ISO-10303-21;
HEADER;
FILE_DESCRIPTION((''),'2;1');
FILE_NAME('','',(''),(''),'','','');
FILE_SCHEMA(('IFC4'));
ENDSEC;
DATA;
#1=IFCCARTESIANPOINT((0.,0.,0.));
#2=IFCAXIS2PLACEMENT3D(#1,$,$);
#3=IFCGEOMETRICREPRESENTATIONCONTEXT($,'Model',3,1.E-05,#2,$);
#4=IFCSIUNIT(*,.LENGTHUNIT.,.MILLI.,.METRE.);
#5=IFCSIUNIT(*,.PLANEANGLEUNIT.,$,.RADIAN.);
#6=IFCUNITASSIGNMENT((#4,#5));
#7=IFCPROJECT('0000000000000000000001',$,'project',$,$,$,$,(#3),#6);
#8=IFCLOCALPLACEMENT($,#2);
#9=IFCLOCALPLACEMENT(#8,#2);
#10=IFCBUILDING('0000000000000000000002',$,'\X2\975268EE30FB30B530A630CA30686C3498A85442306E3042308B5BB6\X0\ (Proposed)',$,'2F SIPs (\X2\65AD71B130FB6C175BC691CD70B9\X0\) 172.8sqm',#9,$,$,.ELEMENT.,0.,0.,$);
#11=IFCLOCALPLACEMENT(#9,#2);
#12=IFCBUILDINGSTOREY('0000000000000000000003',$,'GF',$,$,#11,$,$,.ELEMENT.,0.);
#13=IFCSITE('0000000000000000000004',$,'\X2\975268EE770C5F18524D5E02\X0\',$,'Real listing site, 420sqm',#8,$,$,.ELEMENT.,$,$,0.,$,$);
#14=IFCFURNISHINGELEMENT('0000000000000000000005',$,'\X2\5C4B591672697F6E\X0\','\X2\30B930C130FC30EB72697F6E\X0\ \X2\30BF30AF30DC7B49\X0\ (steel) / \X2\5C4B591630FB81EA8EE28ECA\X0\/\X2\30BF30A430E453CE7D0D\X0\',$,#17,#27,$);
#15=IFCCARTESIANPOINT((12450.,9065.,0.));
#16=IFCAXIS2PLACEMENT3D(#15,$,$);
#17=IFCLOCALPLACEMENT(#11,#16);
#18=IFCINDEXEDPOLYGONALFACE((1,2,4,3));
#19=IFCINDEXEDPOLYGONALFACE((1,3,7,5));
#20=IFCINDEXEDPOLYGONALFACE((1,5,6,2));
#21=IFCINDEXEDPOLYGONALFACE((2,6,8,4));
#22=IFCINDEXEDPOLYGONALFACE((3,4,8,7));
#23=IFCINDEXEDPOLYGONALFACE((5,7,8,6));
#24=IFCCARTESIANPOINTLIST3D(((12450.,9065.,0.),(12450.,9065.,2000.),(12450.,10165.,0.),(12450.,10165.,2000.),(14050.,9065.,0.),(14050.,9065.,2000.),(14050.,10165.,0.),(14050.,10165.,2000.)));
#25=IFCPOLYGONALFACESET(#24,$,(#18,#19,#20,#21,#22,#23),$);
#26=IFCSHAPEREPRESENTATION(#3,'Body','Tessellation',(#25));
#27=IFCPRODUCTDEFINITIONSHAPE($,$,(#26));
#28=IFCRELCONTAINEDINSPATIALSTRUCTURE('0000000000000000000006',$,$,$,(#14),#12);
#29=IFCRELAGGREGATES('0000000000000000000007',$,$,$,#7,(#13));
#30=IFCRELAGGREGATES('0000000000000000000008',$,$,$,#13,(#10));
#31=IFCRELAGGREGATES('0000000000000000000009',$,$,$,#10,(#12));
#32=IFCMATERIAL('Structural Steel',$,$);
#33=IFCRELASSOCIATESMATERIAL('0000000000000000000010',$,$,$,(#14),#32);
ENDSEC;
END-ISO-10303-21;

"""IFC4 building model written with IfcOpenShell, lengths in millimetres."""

from ifc_helpers import new_model, si_unit, frame, frame_2d, origin, place, context, project, spatial, rectangle, extrude, material, element, save


model = new_model("IFC4")

# Units and contexts
model_context = context("Model", 3, precision=1e-05, world=origin())
ifc_project = project(units=[si_unit("LENGTHUNIT", "METRE", prefix="MILLI"), si_unit("PLANEANGLEUNIT", "RADIAN")], contexts=[model_context])

# Site, building, storey
site_placement = place(None, origin())
site = spatial("IfcSite", under=ifc_project, at=site_placement, Name="青森県弘前市", ObjectType="Real listing site, 420sqm", CompositionType="ELEMENT", RefElevation=0.0)
building_placement = place(site_placement, origin())
building = spatial("IfcBuilding", under=site, at=building_placement, Name="青森・サウナと水風呂のある家 (Proposed)", ObjectType="2F SIPs (断熱・気密重点) 172.8sqm", CompositionType="ELEMENT", ElevationOfRefHeight=0.0, ElevationOfTerrain=0.0)
storey_placement = place(building_placement, origin())
storey = spatial("IfcBuildingStorey", under=building, at=storey_placement, Name="GF", CompositionType="ELEMENT", Elevation=0.0)

# Shared definitions
ifc_material_1 = material(Name="Structural Steel")

# Furnishing element
furnishing_1_placement = place(storey_placement, frame((12450.0, 9065.0, 0.0)))
element("IfcFurnishingElement", 1, at=furnishing_1_placement, inside=storey, material=ifc_material_1, Name="屋外物置", Description="スチール物置 タクボ等 (steel) / 屋外・自転車/タイヤ収納", context=model_context, shape_type="SweptSolid", body=[
    extrude(rectangle(XDim=1600.0, YDim=1100.0, at=frame_2d((800.0, 550.0))), frame((12450.0, 9065.0, 0.0)), (0.0, 0.0, 1.0), 2000.0),
])

save(model, "model.ifc")
